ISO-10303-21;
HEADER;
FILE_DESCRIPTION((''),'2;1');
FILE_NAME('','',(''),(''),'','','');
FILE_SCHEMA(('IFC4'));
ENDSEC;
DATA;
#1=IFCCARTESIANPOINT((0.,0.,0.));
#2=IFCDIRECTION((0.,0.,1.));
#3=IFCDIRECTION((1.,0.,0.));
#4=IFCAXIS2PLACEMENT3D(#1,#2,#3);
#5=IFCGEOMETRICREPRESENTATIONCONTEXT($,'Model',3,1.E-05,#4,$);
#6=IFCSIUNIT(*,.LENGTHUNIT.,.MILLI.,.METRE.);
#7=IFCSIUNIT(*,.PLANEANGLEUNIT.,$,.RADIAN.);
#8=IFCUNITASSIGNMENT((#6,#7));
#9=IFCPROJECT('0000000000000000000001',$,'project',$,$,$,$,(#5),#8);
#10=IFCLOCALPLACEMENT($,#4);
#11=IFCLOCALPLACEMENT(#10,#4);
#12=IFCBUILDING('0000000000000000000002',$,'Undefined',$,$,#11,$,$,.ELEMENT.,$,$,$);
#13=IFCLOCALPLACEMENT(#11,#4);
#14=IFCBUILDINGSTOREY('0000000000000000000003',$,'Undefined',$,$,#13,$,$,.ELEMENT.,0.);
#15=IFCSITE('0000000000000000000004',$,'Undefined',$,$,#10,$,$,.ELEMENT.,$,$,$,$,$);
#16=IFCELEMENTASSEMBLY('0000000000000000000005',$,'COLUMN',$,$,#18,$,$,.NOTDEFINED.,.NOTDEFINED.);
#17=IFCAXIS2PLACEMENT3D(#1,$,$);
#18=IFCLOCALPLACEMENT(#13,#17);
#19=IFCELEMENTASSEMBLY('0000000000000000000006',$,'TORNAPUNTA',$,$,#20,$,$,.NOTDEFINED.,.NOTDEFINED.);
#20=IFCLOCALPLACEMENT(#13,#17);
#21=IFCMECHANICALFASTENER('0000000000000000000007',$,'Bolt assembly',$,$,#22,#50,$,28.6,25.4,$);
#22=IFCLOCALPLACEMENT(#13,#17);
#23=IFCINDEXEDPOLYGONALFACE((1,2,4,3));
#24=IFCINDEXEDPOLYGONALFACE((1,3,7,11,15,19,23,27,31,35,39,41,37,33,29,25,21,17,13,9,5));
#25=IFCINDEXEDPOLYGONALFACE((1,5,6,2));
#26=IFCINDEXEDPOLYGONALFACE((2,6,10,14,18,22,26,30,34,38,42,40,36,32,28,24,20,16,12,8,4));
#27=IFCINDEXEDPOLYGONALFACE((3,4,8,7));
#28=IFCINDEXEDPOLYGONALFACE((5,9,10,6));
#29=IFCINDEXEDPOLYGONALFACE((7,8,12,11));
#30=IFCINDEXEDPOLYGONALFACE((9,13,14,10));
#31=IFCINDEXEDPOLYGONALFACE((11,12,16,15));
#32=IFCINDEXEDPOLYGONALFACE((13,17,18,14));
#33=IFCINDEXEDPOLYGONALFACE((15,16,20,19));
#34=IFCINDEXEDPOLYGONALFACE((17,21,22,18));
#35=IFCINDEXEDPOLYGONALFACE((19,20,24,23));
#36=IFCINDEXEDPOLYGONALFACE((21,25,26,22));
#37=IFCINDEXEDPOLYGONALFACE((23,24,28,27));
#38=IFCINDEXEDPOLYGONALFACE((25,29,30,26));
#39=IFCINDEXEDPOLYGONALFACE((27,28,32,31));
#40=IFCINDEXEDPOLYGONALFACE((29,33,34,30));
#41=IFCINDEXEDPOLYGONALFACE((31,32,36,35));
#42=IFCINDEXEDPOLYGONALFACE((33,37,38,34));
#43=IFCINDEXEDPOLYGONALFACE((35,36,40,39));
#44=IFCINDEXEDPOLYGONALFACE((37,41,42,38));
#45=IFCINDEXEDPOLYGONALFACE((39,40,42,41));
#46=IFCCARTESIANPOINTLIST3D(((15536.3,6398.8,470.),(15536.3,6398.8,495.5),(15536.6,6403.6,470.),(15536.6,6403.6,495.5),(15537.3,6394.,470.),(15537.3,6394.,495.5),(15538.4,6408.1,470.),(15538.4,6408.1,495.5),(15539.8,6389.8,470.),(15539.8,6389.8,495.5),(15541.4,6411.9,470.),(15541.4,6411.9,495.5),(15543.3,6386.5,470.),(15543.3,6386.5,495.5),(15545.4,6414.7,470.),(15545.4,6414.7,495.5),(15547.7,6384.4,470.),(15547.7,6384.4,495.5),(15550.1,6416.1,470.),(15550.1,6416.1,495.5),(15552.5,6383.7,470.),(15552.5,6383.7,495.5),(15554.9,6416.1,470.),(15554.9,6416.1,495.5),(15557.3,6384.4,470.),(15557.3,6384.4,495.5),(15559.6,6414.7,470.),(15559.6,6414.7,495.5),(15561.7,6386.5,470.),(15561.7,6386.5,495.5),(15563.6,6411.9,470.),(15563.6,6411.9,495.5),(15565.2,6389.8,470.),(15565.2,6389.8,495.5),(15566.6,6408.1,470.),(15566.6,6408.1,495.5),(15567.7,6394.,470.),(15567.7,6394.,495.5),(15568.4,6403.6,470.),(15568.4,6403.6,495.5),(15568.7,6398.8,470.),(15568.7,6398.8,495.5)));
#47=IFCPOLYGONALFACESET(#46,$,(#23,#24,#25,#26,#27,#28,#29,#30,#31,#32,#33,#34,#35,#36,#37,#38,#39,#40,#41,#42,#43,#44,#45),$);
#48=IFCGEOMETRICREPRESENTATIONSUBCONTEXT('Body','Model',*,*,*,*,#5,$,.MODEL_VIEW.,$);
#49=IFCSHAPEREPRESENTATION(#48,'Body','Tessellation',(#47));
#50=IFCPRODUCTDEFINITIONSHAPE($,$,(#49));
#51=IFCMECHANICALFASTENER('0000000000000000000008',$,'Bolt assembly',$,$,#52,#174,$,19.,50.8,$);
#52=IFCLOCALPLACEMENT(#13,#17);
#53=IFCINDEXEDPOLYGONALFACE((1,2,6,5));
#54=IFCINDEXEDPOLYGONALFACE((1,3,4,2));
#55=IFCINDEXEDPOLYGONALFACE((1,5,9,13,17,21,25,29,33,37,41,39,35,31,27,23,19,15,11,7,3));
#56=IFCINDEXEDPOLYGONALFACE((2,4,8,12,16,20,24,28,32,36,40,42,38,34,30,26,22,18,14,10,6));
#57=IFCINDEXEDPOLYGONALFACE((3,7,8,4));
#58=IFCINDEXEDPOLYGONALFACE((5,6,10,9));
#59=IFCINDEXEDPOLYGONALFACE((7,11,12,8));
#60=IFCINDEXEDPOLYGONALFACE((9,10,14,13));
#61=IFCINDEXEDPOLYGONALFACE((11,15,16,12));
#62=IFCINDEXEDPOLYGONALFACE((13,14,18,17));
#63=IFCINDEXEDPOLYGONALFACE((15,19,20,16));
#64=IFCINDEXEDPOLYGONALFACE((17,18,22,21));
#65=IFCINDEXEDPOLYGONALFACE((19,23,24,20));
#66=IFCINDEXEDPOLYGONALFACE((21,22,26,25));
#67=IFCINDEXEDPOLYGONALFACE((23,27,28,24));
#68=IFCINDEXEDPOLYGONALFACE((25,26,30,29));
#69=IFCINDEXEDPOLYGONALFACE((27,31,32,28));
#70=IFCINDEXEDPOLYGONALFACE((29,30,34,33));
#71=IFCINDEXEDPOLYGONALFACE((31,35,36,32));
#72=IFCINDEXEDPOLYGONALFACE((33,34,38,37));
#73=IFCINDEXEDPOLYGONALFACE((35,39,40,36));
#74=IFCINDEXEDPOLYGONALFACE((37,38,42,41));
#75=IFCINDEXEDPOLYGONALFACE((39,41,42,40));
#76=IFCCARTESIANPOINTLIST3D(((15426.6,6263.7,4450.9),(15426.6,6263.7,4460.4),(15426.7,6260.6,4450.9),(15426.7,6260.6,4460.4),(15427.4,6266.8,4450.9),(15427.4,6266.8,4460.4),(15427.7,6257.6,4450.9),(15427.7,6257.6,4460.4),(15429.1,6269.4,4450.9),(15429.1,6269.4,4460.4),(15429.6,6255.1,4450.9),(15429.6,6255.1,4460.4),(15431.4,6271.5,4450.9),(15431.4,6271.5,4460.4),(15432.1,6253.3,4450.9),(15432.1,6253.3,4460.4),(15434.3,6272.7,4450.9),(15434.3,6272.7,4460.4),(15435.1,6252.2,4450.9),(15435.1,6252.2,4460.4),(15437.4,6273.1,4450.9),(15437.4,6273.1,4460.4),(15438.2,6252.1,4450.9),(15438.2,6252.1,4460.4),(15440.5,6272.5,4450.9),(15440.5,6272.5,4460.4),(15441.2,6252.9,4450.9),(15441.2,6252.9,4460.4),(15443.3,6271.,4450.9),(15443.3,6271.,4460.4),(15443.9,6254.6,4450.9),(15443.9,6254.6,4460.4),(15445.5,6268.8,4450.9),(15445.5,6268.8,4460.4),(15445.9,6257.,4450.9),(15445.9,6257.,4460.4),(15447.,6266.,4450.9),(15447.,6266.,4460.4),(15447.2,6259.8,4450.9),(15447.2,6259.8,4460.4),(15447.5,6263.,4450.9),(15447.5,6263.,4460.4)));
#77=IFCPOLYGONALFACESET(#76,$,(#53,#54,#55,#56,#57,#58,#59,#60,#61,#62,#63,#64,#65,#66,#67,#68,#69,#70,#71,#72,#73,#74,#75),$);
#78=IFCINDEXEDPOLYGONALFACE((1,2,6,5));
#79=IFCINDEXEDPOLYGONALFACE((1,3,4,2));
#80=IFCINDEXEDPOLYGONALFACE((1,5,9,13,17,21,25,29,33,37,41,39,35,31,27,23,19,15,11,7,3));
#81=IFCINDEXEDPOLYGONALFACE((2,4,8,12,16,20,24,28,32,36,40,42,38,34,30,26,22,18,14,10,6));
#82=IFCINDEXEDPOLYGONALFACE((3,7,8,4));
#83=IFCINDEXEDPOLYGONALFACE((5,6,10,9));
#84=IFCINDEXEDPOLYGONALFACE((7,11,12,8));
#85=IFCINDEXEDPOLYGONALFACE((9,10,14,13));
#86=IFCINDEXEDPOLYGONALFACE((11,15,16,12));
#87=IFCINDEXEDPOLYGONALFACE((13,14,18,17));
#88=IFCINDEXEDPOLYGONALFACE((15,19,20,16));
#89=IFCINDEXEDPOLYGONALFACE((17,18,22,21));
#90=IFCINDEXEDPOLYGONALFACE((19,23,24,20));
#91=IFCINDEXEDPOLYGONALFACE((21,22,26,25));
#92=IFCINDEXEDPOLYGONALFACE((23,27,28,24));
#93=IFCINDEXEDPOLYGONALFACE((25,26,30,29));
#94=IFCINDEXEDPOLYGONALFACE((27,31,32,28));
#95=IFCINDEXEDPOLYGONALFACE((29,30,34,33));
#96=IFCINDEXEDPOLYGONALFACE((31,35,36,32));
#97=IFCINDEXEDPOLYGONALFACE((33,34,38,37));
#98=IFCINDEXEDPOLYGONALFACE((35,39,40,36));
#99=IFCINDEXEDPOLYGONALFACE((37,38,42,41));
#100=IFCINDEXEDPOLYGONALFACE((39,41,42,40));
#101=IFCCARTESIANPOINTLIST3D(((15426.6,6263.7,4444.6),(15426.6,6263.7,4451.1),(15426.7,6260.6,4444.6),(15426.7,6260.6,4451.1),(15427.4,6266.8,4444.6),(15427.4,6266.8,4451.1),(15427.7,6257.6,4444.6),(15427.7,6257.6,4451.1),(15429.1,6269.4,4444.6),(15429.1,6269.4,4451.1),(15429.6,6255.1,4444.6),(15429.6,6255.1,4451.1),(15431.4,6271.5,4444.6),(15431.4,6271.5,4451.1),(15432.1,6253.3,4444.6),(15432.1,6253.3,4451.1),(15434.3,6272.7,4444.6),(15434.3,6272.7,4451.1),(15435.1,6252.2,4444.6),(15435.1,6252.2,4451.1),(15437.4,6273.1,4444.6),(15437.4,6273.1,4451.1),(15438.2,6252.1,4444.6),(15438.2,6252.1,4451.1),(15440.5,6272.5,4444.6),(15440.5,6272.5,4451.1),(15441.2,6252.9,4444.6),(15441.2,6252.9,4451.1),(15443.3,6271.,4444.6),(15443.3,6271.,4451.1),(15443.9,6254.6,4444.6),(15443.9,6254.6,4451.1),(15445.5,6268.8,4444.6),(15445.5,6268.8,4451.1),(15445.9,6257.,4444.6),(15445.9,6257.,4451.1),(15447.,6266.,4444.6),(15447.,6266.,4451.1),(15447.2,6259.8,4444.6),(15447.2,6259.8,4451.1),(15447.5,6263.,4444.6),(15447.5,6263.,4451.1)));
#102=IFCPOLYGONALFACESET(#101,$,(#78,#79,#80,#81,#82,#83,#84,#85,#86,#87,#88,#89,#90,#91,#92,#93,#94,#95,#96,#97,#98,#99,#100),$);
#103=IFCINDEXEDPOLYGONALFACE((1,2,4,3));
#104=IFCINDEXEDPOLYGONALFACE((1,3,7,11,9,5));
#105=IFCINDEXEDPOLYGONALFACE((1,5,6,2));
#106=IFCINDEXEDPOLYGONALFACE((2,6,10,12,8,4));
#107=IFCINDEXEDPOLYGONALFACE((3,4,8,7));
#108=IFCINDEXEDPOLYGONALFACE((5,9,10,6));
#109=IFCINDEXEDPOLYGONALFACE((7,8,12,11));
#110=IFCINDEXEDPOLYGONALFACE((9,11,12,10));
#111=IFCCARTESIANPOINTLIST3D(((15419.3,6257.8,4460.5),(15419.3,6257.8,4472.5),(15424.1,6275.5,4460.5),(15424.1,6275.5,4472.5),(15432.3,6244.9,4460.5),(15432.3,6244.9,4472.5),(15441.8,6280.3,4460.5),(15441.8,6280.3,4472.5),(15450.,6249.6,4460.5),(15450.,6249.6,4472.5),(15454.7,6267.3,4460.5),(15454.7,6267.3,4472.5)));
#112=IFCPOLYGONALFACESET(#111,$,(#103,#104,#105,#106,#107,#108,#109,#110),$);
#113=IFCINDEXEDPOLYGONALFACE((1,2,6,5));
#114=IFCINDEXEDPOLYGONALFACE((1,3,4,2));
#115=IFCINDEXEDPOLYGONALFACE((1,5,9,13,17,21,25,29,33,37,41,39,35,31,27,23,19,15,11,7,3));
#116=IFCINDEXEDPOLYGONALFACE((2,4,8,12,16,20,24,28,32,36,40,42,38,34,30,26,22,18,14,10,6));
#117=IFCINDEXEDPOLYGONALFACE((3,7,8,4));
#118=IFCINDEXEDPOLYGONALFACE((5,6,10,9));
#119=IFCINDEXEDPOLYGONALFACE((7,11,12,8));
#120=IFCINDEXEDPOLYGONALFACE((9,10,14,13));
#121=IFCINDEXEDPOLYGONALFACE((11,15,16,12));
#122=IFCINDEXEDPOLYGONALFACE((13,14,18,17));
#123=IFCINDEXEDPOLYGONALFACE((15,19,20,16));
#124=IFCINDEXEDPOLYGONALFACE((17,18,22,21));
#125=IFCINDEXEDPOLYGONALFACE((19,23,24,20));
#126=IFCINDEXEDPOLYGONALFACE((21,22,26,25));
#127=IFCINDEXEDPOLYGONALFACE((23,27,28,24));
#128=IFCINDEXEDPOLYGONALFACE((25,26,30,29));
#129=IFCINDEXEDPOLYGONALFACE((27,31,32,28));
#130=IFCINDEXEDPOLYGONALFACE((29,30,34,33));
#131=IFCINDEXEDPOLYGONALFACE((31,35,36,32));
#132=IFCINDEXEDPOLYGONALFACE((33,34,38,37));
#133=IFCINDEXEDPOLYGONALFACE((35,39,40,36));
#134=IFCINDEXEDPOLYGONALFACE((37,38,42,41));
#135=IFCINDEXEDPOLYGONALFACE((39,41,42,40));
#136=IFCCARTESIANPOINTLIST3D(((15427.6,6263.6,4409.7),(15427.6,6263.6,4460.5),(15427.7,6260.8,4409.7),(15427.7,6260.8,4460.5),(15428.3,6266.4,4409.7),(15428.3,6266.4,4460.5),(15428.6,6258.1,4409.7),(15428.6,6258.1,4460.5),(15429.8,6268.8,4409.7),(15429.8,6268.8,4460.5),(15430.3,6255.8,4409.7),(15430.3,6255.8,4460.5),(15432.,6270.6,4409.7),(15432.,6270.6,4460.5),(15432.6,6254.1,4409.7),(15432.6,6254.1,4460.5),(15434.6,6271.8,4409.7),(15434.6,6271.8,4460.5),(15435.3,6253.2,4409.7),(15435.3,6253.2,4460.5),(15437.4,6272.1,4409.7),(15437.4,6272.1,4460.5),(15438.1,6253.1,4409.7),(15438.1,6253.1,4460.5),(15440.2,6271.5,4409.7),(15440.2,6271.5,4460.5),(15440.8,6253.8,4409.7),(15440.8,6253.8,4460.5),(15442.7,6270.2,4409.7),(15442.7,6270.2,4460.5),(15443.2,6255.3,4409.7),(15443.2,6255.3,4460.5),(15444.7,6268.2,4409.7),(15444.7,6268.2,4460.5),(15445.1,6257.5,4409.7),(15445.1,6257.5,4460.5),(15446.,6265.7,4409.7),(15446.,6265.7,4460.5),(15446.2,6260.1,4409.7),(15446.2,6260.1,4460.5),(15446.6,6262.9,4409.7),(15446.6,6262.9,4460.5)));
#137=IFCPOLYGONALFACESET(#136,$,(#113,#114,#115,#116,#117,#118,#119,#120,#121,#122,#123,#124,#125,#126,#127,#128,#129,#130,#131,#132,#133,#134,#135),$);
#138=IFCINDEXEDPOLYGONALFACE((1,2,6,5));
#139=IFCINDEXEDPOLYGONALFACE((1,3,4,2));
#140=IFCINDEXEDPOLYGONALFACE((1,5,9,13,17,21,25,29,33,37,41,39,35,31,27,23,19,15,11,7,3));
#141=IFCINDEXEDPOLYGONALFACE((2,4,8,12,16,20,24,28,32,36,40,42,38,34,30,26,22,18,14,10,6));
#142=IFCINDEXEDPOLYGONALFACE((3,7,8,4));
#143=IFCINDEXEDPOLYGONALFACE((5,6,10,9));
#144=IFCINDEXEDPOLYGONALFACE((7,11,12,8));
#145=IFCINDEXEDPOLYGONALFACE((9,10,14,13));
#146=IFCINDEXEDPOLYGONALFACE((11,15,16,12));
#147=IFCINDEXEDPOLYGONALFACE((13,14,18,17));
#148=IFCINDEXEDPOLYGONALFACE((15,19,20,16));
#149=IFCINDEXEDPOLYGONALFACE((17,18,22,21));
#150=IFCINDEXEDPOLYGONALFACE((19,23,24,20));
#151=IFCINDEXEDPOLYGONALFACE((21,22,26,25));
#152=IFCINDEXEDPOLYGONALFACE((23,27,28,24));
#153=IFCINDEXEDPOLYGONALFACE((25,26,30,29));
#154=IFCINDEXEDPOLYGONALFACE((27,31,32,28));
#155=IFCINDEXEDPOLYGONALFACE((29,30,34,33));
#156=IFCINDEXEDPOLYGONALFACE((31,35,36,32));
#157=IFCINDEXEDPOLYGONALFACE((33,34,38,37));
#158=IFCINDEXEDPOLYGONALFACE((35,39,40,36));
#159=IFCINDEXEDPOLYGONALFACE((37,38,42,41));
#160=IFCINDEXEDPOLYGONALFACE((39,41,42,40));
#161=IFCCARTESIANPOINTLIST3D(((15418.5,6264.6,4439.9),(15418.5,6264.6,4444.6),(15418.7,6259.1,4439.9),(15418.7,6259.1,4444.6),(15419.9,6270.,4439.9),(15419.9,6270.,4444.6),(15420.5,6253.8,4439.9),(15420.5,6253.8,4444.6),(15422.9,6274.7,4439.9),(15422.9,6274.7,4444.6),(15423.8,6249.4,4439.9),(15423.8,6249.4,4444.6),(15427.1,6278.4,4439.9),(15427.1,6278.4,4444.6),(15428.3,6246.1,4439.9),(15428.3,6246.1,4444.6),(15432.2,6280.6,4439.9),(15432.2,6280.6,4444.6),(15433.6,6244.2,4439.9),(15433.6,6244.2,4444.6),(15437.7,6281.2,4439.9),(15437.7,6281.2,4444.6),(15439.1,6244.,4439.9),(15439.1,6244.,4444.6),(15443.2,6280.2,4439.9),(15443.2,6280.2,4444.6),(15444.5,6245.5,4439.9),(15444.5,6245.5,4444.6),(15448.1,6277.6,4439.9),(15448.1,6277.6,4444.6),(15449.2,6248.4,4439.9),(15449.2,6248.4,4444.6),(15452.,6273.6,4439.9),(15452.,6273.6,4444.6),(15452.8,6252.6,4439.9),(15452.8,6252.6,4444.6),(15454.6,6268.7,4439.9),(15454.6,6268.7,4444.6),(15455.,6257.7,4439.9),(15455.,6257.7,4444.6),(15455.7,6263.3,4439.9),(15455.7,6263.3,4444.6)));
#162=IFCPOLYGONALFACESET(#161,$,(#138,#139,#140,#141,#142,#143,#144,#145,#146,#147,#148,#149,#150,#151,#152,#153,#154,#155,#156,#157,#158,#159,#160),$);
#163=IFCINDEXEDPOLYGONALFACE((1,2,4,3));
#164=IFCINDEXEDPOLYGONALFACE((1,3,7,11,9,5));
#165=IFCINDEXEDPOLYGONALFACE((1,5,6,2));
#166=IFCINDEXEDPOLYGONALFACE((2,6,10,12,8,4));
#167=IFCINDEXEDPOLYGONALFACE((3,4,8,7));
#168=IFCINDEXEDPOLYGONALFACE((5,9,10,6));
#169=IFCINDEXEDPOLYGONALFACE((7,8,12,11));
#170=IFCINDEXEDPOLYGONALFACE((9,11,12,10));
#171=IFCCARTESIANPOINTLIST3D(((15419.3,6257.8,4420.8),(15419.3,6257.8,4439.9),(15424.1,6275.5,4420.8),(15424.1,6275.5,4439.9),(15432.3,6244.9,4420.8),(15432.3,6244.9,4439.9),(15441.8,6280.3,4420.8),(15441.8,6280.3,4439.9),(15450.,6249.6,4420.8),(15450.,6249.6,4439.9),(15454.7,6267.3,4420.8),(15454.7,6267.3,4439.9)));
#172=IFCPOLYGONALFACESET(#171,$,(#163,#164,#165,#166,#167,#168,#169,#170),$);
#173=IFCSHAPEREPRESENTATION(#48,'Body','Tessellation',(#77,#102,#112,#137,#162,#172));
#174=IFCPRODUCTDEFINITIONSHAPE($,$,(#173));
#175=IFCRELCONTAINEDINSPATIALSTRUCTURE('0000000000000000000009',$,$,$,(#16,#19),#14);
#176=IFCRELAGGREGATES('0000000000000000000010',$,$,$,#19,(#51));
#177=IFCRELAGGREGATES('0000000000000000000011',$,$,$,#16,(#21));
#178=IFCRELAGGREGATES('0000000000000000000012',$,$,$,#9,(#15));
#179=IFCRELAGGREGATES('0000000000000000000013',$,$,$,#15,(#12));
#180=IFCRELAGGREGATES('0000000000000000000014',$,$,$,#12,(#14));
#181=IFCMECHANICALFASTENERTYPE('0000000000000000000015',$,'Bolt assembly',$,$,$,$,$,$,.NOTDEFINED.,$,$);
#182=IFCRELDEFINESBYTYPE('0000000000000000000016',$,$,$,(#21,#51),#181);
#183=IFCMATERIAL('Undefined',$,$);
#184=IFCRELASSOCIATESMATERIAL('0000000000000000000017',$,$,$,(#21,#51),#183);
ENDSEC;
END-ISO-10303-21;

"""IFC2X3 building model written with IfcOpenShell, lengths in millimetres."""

from ifc_helpers import new_model, si_unit, frame, origin_with_axes, origin_2d_with_axis, place, context, subcontext, project, spatial, polyline, circle, outline, extrude, source, transform, mapped, material, type_object, element, aggregate, save


model = new_model("IFC2X3")

# Units and contexts
model_context = context("Model", 3, precision=1e-05, world=origin_with_axes())
body_context = subcontext(model_context, "Body", "Model", "MODEL_VIEW")
ifc_project = project(units=[si_unit("LENGTHUNIT", "METRE", prefix="MILLI"), si_unit("PLANEANGLEUNIT", "RADIAN")], contexts=[model_context])

# Site, building, storey
site_placement = place(None, origin_with_axes())
site = spatial("IfcSite", under=ifc_project, at=site_placement, Name="Undefined", CompositionType="ELEMENT")
building_placement = place(site_placement, origin_with_axes())
building = spatial("IfcBuilding", under=site, at=building_placement, Name="Undefined", CompositionType="ELEMENT")
storey_placement = place(building_placement, origin_with_axes())
storey = spatial("IfcBuildingStorey", under=building, at=storey_placement, Name="Undefined", CompositionType="ELEMENT", Elevation=0.0)

# Element assembly
assembly_1_placement = place(storey_placement, origin_with_axes())
assembly_1 = element("IfcElementAssembly", 1, at=assembly_1_placement, inside=storey, Name="COLUMN", AssemblyPlace="NOTDEFINED", PredefinedType="NOTDEFINED")

# Element assembly
assembly_2_placement = place(storey_placement, origin_with_axes())
assembly_2 = element("IfcElementAssembly", 2, at=assembly_2_placement, inside=storey, Name="TORNAPUNTA", AssemblyPlace="NOTDEFINED", PredefinedType="NOTDEFINED")

# Shared definitions
ifc_material_1 = material(Name="Undefined")
mechanical_fastener_type = type_object("IfcMechanicalFastenerType", Name="Bolt assembly")

# Mechanical fasteners
shared_shape_1 = source(origin_with_axes(), body_context, "Body", "SweptSolid", [
    extrude(circle(Radius=16.3, at=origin_2d_with_axis()), frame((0.0, -25.4, 0.0), z_axis=(0.0, 1.0, 0.0), x_axis=(1.0, 0.0, 0.0)), (0.0, 0.0, 1.0), 25.5),
])
mechanical_fastener_1_placement = place(assembly_1_placement, frame((15552.5, 6400.0, 495.4), z_axis=(-1.0, 0.0, 0.0), x_axis=(0.0, -1.0, 0.0)))
mechanical_fastener_1 = element("IfcMechanicalFastener", 3, at=mechanical_fastener_1_placement, type_object=mechanical_fastener_type, material=ifc_material_1, Name="Bolt assembly", NominalDiameter=28.6, NominalLength=25.4, context=body_context, shape_type="MappedRepresentation", body=[
    mapped(shared_shape_1, transform((0.0, 0.0, 0.0))),
])
shared_shape_2 = source(origin_with_axes(), body_context, "Body", "SweptSolid", [
    extrude(circle(Radius=10.5, at=origin_2d_with_axis()), frame((0.0, -9.4, 0.0), z_axis=(0.0, 1.0, 0.0), x_axis=(1.0, 0.0, 0.0)), (0.0, 0.0, 1.0), 9.5),
    extrude(circle(Radius=10.5, at=origin_2d_with_axis()), frame((0.0, -0.1, 0.0), z_axis=(0.0, 1.0, 0.0), x_axis=(1.0, 0.0, 0.0)), (0.0, 0.0, 1.0), 6.5),
    extrude(outline(polyline([(15.9, -9.2), (15.9, 9.2), (0.0, 18.3), (-15.9, 9.2), (-15.9, -9.2), (0.0, -18.3), (15.9, -9.2)])), frame((0.0, -21.4, 0.0), z_axis=(0.0, 1.0, 0.0), x_axis=(1.0, 0.0, 0.0)), (0.0, 0.0, 1.0), 11.9),
    extrude(circle(Radius=9.5, at=origin_2d_with_axis()), frame((0.0, -9.5, 0.0), z_axis=(0.0, 1.0, 0.0), x_axis=(1.0, 0.0, 0.0)), (0.0, 0.0, 1.0), 50.8),
    extrude(circle(Radius=18.7, at=origin_2d_with_axis()), frame((0.0, 6.4, 0.0), z_axis=(0.0, 1.0, 0.0), x_axis=(1.0, 0.0, 0.0)), (0.0, 0.0, 1.0), 4.8),
    extrude(outline(polyline([(15.9, -9.2), (15.9, 9.2), (0.0, 18.3), (-15.9, 9.2), (-15.9, -9.2), (0.0, -18.3), (15.9, -9.2)])), frame((0.0, 11.2, 0.0), z_axis=(0.0, 1.0, 0.0), x_axis=(1.0, 0.0, 0.0)), (0.0, 0.0, 1.0), 19.1),
])
mechanical_fastener_2_placement = place(assembly_2_placement, frame((15437.0, 6262.6, 4451.0), z_axis=(0.707107, -0.707107, 0.0), x_axis=(-0.707107, -0.707107, 0.0)))
mechanical_fastener_2 = element("IfcMechanicalFastener", 4, at=mechanical_fastener_2_placement, type_object=mechanical_fastener_type, material=ifc_material_1, Name="Bolt assembly", NominalDiameter=19.0, NominalLength=50.8, context=body_context, shape_type="MappedRepresentation", body=[
    mapped(shared_shape_2, transform((0.0, 0.0, 0.0))),
])
aggregate(assembly_2, [mechanical_fastener_2])

aggregate(assembly_1, [mechanical_fastener_1])

save(model, "model.ifc")
